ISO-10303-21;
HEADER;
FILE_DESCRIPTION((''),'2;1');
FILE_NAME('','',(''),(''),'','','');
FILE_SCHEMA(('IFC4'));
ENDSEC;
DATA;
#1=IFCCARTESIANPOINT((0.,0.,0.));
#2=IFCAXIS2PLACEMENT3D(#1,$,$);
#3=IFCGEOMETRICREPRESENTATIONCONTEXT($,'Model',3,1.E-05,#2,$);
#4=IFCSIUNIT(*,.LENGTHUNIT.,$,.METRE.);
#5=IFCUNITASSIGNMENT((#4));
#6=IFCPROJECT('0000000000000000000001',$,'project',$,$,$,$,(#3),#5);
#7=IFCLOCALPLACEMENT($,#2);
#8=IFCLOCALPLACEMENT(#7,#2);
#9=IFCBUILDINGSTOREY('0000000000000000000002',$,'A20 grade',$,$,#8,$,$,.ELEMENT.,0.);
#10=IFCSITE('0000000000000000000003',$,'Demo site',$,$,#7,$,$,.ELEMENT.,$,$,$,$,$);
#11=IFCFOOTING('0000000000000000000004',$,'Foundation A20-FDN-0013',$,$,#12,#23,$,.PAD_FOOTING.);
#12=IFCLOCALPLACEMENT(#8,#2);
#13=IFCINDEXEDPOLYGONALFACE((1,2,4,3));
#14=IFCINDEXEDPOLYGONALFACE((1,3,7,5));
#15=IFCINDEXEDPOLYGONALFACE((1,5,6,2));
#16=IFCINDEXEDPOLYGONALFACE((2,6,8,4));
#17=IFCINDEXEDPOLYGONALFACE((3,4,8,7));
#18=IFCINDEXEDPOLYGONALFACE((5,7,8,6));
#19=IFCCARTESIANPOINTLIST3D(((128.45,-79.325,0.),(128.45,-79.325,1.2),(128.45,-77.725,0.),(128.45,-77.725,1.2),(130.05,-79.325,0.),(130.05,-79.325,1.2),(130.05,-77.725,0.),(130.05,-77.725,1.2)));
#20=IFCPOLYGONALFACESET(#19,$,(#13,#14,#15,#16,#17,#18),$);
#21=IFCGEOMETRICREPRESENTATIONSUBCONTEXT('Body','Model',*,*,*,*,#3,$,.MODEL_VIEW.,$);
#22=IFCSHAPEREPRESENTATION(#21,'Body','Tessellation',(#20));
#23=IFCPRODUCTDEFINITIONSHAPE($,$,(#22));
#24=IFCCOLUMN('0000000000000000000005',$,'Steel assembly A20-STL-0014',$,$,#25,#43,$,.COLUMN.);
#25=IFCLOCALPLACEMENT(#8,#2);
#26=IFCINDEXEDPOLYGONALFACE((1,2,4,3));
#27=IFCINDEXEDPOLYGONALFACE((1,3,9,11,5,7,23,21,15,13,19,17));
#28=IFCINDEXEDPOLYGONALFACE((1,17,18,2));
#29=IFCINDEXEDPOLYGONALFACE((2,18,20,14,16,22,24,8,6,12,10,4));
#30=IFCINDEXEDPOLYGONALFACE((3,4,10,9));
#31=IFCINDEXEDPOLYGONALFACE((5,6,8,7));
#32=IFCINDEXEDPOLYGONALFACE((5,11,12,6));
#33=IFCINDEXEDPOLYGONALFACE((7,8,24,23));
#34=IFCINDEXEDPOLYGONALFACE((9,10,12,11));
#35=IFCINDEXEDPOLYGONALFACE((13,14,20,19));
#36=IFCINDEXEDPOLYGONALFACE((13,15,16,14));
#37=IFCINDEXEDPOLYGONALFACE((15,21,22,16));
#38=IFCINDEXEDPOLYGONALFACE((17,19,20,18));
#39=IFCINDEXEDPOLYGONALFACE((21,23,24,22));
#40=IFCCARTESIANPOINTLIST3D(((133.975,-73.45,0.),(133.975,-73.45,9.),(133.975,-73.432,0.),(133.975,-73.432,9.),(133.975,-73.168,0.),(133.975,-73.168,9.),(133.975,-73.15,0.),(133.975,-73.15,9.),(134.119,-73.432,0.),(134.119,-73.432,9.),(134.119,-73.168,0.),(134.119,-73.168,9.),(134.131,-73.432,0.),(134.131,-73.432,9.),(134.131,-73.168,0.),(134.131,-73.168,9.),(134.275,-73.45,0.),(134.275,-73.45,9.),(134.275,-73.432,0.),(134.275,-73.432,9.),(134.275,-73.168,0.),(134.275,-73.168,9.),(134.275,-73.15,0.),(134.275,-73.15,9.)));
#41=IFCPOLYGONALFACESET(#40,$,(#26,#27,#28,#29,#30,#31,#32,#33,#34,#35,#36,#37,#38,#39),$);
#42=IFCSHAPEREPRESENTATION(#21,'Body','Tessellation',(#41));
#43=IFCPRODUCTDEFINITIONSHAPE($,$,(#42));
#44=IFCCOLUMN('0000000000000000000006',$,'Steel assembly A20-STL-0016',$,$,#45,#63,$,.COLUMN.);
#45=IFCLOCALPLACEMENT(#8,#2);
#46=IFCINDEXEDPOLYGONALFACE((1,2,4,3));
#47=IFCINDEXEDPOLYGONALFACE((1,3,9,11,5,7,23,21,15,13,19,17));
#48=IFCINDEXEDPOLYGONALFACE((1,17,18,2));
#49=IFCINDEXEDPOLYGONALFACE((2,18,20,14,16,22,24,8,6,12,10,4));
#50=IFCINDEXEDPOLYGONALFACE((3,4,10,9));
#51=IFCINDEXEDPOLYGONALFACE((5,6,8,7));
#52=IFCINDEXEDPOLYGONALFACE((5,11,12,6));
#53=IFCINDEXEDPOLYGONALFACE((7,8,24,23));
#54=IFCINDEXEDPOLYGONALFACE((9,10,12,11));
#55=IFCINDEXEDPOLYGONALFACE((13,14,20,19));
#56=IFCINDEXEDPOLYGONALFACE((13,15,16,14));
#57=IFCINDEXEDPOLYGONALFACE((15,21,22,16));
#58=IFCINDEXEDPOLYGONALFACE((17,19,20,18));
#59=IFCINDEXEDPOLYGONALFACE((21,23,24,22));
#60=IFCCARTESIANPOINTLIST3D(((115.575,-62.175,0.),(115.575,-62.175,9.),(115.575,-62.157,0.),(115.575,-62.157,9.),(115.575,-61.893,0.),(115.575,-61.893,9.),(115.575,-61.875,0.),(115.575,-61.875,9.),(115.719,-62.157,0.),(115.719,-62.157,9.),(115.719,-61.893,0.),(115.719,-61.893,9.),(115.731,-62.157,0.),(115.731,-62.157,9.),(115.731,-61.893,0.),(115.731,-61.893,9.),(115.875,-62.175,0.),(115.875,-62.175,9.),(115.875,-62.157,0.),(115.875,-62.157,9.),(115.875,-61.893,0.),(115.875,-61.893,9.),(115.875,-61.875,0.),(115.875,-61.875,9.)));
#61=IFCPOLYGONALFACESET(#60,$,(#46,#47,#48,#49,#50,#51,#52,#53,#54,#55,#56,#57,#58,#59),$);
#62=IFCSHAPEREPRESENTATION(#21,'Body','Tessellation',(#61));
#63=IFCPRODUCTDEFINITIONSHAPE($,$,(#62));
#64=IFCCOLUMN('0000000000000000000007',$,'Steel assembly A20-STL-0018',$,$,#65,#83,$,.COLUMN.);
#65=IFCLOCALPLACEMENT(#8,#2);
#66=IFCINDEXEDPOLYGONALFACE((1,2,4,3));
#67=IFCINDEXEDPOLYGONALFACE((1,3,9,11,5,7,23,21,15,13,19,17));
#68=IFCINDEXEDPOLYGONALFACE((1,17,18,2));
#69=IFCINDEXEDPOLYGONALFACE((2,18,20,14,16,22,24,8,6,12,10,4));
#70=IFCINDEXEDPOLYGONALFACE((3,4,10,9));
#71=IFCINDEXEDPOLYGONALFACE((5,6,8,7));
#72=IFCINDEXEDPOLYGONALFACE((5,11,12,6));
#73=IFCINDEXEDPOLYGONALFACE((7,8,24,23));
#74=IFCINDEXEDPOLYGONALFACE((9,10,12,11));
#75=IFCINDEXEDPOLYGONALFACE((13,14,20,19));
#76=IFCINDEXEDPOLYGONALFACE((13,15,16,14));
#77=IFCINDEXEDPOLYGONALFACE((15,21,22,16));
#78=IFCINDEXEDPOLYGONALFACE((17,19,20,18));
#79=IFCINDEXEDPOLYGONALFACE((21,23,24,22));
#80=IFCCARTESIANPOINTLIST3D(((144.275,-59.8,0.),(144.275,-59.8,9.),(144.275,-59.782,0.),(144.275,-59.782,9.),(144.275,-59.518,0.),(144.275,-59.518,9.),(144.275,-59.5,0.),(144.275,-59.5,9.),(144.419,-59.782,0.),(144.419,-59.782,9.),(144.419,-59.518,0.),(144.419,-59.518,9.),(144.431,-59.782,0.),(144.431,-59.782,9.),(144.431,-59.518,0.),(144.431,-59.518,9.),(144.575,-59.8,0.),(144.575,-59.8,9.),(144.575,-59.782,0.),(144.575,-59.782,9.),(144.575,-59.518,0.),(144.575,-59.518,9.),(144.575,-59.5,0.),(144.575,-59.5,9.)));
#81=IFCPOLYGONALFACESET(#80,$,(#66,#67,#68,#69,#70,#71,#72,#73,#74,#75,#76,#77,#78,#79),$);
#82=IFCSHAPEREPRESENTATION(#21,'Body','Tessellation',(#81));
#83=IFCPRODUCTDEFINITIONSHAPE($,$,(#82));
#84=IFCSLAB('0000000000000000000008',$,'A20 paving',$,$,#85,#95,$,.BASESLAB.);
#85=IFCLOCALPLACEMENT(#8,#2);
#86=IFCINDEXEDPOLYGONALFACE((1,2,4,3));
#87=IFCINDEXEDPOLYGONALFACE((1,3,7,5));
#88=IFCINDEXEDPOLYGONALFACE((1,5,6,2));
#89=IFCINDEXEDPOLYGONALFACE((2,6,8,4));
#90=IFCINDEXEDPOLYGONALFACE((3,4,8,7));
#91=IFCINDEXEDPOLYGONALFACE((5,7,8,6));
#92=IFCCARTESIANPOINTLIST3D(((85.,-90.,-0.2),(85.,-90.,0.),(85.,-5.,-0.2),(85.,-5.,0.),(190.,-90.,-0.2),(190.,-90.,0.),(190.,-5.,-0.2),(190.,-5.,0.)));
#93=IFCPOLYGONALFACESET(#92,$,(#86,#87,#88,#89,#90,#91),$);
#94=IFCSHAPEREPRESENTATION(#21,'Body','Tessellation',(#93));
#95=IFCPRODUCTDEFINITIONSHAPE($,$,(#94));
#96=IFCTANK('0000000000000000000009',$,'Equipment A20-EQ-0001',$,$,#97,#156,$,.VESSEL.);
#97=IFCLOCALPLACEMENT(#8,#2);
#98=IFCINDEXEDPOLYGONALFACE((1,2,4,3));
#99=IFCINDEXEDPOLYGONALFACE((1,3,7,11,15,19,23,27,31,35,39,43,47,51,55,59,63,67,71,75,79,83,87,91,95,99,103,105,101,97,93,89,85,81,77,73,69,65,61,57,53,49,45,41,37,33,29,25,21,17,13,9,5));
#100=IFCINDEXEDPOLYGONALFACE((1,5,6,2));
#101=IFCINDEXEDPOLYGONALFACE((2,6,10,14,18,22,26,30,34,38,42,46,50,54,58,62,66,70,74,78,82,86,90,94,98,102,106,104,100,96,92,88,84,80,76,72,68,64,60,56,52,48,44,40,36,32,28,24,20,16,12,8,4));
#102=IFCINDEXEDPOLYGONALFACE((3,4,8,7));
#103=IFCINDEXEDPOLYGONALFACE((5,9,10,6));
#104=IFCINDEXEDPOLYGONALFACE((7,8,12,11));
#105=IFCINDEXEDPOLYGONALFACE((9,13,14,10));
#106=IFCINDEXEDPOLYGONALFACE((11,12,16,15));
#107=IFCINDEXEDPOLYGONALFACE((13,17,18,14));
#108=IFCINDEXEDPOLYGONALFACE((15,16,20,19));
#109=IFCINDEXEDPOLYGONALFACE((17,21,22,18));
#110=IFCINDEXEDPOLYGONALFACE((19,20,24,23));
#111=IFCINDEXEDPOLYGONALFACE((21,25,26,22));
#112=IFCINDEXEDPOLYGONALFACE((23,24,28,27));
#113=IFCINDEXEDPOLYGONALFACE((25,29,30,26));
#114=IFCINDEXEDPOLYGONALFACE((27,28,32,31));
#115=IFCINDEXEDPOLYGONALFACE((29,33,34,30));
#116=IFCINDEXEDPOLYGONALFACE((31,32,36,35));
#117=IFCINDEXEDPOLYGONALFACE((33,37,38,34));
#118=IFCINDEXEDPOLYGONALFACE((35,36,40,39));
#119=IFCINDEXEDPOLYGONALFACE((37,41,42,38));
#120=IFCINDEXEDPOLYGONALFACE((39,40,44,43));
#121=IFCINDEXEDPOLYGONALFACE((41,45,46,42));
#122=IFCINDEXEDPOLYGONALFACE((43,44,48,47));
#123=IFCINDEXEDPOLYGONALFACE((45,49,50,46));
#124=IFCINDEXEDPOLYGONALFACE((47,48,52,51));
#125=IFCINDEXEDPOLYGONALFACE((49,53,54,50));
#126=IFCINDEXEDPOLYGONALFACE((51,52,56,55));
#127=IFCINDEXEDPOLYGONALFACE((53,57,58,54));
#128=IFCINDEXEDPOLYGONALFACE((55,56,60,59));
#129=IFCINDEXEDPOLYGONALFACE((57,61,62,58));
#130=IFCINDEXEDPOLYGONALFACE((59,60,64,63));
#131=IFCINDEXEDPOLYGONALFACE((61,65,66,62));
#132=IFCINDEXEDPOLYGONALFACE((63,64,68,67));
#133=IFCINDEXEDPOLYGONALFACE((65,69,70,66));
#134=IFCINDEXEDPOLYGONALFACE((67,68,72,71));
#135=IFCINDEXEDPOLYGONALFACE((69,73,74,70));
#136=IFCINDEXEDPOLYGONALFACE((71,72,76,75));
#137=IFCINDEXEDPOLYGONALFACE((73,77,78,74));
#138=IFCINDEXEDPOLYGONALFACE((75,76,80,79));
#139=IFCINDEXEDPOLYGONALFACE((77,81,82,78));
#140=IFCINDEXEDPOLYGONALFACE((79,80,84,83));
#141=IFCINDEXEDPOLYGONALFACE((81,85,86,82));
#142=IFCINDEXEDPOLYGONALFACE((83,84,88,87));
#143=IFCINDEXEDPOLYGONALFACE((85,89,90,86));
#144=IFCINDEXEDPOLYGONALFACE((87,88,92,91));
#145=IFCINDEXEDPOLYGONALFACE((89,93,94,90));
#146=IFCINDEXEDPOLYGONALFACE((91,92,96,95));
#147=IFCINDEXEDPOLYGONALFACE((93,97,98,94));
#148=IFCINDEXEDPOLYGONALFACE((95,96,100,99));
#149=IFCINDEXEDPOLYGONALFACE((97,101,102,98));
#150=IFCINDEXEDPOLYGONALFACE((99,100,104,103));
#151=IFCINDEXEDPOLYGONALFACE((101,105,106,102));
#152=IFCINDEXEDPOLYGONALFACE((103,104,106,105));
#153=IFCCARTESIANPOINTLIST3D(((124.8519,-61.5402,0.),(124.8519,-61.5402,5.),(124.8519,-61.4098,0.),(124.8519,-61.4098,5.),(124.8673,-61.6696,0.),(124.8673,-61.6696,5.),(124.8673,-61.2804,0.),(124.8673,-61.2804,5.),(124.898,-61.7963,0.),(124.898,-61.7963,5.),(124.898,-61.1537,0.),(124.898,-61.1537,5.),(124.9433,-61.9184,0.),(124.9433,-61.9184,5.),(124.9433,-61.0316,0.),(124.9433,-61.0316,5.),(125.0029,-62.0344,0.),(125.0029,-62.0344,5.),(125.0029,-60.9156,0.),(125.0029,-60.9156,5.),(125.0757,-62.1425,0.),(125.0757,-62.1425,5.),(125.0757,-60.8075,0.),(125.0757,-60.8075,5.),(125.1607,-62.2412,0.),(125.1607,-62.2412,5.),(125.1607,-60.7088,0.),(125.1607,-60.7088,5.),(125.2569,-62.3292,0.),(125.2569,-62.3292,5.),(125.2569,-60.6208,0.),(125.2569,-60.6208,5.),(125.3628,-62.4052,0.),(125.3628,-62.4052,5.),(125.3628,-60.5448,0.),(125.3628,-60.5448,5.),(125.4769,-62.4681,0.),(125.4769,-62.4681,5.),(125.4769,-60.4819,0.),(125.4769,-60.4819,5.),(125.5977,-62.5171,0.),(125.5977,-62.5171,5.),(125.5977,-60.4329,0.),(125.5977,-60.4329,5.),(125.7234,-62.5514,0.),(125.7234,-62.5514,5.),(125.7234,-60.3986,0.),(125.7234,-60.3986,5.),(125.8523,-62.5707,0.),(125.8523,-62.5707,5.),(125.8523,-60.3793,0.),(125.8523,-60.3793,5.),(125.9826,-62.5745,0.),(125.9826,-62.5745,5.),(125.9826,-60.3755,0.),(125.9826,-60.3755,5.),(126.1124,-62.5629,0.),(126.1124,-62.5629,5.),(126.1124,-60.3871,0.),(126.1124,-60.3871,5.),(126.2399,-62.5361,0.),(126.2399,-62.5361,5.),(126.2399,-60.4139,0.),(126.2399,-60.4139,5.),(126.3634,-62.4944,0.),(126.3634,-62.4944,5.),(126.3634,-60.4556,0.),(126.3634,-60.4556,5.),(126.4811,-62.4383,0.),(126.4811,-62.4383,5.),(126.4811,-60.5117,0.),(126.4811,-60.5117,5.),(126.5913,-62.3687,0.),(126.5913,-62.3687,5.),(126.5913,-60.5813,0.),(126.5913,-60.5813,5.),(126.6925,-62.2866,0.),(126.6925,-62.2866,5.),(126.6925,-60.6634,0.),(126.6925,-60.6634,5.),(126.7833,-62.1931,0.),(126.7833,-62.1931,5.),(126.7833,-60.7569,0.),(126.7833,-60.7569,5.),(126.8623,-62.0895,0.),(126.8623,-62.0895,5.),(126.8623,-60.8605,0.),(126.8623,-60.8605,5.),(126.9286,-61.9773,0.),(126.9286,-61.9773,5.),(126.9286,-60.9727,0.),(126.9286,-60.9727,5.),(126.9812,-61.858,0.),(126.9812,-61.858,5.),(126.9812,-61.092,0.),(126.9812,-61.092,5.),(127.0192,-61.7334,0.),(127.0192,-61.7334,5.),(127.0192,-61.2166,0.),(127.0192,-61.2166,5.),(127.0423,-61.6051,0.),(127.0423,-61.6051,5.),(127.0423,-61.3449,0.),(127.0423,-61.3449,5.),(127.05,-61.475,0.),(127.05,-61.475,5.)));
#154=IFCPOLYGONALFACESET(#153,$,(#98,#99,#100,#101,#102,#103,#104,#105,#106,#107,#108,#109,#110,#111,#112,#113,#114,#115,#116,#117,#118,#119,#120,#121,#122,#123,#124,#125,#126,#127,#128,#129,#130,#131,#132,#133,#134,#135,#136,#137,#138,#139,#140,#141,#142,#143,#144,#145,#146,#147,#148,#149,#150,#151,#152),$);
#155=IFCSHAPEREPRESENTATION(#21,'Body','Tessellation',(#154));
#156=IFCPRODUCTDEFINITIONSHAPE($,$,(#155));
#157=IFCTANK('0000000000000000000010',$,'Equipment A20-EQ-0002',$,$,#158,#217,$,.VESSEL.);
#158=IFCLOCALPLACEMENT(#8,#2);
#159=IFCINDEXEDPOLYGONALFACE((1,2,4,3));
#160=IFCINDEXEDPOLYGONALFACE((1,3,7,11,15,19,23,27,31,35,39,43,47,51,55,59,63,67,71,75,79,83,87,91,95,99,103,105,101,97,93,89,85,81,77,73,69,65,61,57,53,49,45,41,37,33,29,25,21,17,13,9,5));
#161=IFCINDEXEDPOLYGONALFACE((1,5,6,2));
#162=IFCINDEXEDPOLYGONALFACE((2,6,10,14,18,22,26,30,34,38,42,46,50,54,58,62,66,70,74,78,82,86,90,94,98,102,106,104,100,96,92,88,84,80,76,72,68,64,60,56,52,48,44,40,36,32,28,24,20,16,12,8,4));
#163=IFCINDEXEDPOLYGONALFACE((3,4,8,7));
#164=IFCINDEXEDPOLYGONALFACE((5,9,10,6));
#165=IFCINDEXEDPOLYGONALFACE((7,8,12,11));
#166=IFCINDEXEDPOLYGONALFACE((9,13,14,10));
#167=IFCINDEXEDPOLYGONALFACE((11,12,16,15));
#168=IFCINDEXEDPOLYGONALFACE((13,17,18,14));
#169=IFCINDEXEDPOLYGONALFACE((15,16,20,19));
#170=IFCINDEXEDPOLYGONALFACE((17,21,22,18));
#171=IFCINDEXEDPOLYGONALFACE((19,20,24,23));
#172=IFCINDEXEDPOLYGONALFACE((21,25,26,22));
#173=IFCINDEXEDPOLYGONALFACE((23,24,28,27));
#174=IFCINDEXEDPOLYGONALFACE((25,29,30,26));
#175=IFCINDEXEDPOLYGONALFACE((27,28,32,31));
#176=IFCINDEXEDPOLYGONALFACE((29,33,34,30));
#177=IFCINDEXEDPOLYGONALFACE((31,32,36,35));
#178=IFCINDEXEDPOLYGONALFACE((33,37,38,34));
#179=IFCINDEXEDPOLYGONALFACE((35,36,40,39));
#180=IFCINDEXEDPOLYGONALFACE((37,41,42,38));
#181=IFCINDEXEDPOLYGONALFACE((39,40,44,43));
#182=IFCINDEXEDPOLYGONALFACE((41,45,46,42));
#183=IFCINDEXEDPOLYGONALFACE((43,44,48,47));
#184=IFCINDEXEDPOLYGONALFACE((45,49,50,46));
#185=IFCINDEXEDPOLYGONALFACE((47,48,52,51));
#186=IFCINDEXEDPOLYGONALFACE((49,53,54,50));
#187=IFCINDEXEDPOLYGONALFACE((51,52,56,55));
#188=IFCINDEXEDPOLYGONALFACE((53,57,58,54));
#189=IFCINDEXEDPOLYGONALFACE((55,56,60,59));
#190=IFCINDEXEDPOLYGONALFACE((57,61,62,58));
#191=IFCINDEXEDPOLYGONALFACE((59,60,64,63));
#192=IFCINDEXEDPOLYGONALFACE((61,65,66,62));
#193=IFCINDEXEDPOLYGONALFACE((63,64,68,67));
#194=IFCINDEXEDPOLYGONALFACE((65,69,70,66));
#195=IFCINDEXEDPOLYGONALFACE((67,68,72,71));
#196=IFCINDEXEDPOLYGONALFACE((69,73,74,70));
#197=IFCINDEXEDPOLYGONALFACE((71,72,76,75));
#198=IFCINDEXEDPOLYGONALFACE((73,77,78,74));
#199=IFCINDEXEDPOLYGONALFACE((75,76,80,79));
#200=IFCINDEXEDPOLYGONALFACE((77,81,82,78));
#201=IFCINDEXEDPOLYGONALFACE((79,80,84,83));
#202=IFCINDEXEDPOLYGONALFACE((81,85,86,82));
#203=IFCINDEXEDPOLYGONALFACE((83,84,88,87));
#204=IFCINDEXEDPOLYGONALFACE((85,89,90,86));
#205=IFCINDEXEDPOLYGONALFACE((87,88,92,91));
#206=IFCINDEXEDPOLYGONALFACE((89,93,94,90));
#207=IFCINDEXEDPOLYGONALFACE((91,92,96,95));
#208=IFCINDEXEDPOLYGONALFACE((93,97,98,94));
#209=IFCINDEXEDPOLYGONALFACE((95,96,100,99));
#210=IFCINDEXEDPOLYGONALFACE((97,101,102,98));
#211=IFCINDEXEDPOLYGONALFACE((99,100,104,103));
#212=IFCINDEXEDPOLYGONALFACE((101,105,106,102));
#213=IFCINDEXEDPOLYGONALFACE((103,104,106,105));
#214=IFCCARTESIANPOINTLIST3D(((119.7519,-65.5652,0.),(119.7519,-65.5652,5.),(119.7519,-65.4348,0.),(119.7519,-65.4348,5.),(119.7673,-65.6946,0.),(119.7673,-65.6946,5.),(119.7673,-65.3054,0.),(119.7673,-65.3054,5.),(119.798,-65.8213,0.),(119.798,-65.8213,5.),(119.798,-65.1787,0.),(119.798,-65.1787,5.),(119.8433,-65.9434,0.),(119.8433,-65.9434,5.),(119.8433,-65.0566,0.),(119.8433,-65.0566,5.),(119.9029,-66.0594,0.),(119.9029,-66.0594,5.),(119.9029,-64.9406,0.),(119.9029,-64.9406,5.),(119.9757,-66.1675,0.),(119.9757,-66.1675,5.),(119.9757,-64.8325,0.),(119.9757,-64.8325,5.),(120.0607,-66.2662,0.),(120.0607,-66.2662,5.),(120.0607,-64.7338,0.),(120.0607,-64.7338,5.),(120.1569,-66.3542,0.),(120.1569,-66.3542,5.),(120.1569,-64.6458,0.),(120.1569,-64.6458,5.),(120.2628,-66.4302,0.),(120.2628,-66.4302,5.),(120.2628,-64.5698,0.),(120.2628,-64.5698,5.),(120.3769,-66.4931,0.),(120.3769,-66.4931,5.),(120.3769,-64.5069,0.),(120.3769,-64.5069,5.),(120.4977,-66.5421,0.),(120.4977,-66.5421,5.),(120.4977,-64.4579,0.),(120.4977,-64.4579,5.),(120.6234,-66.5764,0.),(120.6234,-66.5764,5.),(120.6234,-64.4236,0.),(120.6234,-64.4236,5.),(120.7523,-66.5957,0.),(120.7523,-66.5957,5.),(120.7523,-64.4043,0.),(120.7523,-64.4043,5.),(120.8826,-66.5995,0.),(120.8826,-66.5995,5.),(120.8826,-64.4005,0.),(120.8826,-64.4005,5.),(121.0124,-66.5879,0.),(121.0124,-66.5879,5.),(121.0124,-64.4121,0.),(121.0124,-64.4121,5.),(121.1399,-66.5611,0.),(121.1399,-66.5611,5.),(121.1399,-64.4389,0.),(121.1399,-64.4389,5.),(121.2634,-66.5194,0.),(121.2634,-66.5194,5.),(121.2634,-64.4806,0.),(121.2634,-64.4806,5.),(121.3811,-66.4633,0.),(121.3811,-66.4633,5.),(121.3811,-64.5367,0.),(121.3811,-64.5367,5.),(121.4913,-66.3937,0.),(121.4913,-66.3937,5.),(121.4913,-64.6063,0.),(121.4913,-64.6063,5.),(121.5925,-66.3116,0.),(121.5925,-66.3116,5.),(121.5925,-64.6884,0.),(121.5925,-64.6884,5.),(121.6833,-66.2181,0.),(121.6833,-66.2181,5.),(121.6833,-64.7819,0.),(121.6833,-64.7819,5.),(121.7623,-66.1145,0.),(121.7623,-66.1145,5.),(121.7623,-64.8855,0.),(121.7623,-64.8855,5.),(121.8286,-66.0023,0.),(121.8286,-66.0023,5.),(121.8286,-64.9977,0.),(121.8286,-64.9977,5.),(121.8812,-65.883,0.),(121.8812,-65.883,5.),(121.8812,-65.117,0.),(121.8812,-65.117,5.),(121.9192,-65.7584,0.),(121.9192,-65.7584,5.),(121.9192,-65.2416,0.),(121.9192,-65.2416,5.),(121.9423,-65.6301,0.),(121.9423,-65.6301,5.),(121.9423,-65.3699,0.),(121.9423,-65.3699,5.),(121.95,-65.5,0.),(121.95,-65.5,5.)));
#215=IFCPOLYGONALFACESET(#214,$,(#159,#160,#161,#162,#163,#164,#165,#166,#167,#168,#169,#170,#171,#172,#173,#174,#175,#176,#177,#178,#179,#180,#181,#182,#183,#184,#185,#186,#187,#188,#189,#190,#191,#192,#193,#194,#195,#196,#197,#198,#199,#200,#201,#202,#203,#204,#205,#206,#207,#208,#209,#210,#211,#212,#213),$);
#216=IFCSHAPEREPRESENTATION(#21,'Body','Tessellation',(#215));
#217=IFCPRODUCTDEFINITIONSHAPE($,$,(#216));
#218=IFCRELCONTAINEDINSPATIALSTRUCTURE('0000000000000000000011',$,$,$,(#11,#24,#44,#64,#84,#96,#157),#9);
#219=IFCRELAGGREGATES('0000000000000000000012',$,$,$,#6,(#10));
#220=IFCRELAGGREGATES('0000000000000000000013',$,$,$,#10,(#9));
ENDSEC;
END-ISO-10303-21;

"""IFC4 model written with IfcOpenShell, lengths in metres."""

from ifc_helpers import new_model, si_unit, frame, origin, place, context, subcontext, project, spatial, rectangle, circle, i_section, extrude, element, save


model = new_model("IFC4")

# Units and contexts
model_context = context("Model", 3, precision=1e-05, world=origin())
body_context = subcontext(model_context, "Body", "Model", "MODEL_VIEW")
ifc_project = project(units=[si_unit("LENGTHUNIT", "METRE")], contexts=[model_context])

# Site, storey
site_placement = place(None, origin())
site = spatial("IfcSite", under=ifc_project, at=site_placement, Name="Demo site", CompositionType="ELEMENT")
storey_placement = place(site_placement, origin())
storey = spatial("IfcBuildingStorey", under=site, at=storey_placement, Name="A20 grade", CompositionType="ELEMENT", Elevation=0.0)

# Footing
footing_placement = place(storey_placement, frame((129.25, -78.525, 0.0)))
element("IfcFooting", 1, at=footing_placement, inside=storey, Name="Foundation A20-FDN-0013", PredefinedType="PAD_FOOTING", context=body_context, shape_type="SweptSolid", body=[
    extrude(rectangle(XDim=1.6, YDim=1.6), origin(), (0.0, 0.0, 1.0), 1.2),
])

# Columns
for number, where, name in (
    (2, (134.125, -73.3, 0.0), "Steel assembly A20-STL-0014"),
    (3, (115.725, -62.025, 0.0), "Steel assembly A20-STL-0016"),
    (4, (144.425, -59.65, 0.0), "Steel assembly A20-STL-0018"),
):
    element("IfcColumn", number, at=place(storey_placement, frame(where)), inside=storey, Name=name, PredefinedType="COLUMN", context=body_context, shape_type="SweptSolid", body=[
        extrude(i_section(OverallWidth=0.3, OverallDepth=0.3, WebThickness=0.012, FlangeThickness=0.018), origin(), (0.0, 0.0, 1.0), 9.0),
    ])

# Slab
slab_placement = place(storey_placement, frame((137.5, -47.5, -0.2)))
element("IfcSlab", 5, at=slab_placement, inside=storey, Name="A20 paving", PredefinedType="BASESLAB", context=body_context, shape_type="SweptSolid", body=[
    extrude(rectangle(XDim=105.0, YDim=85.0), origin(), (0.0, 0.0, 1.0), 0.2),
])

# Tanks
for number, where, name in (
    (6, (125.95, -61.475, 0.0), "Equipment A20-EQ-0001"),
    (7, (120.85, -65.5, 0.0), "Equipment A20-EQ-0002"),
):
    element("IfcTank", number, at=place(storey_placement, frame(where)), inside=storey, Name=name, PredefinedType="VESSEL", context=body_context, shape_type="SweptSolid", body=[
        extrude(circle(Radius=1.1), origin(), (0.0, 0.0, 1.0), 5.0),
    ])

save(model, "model.ifc")
